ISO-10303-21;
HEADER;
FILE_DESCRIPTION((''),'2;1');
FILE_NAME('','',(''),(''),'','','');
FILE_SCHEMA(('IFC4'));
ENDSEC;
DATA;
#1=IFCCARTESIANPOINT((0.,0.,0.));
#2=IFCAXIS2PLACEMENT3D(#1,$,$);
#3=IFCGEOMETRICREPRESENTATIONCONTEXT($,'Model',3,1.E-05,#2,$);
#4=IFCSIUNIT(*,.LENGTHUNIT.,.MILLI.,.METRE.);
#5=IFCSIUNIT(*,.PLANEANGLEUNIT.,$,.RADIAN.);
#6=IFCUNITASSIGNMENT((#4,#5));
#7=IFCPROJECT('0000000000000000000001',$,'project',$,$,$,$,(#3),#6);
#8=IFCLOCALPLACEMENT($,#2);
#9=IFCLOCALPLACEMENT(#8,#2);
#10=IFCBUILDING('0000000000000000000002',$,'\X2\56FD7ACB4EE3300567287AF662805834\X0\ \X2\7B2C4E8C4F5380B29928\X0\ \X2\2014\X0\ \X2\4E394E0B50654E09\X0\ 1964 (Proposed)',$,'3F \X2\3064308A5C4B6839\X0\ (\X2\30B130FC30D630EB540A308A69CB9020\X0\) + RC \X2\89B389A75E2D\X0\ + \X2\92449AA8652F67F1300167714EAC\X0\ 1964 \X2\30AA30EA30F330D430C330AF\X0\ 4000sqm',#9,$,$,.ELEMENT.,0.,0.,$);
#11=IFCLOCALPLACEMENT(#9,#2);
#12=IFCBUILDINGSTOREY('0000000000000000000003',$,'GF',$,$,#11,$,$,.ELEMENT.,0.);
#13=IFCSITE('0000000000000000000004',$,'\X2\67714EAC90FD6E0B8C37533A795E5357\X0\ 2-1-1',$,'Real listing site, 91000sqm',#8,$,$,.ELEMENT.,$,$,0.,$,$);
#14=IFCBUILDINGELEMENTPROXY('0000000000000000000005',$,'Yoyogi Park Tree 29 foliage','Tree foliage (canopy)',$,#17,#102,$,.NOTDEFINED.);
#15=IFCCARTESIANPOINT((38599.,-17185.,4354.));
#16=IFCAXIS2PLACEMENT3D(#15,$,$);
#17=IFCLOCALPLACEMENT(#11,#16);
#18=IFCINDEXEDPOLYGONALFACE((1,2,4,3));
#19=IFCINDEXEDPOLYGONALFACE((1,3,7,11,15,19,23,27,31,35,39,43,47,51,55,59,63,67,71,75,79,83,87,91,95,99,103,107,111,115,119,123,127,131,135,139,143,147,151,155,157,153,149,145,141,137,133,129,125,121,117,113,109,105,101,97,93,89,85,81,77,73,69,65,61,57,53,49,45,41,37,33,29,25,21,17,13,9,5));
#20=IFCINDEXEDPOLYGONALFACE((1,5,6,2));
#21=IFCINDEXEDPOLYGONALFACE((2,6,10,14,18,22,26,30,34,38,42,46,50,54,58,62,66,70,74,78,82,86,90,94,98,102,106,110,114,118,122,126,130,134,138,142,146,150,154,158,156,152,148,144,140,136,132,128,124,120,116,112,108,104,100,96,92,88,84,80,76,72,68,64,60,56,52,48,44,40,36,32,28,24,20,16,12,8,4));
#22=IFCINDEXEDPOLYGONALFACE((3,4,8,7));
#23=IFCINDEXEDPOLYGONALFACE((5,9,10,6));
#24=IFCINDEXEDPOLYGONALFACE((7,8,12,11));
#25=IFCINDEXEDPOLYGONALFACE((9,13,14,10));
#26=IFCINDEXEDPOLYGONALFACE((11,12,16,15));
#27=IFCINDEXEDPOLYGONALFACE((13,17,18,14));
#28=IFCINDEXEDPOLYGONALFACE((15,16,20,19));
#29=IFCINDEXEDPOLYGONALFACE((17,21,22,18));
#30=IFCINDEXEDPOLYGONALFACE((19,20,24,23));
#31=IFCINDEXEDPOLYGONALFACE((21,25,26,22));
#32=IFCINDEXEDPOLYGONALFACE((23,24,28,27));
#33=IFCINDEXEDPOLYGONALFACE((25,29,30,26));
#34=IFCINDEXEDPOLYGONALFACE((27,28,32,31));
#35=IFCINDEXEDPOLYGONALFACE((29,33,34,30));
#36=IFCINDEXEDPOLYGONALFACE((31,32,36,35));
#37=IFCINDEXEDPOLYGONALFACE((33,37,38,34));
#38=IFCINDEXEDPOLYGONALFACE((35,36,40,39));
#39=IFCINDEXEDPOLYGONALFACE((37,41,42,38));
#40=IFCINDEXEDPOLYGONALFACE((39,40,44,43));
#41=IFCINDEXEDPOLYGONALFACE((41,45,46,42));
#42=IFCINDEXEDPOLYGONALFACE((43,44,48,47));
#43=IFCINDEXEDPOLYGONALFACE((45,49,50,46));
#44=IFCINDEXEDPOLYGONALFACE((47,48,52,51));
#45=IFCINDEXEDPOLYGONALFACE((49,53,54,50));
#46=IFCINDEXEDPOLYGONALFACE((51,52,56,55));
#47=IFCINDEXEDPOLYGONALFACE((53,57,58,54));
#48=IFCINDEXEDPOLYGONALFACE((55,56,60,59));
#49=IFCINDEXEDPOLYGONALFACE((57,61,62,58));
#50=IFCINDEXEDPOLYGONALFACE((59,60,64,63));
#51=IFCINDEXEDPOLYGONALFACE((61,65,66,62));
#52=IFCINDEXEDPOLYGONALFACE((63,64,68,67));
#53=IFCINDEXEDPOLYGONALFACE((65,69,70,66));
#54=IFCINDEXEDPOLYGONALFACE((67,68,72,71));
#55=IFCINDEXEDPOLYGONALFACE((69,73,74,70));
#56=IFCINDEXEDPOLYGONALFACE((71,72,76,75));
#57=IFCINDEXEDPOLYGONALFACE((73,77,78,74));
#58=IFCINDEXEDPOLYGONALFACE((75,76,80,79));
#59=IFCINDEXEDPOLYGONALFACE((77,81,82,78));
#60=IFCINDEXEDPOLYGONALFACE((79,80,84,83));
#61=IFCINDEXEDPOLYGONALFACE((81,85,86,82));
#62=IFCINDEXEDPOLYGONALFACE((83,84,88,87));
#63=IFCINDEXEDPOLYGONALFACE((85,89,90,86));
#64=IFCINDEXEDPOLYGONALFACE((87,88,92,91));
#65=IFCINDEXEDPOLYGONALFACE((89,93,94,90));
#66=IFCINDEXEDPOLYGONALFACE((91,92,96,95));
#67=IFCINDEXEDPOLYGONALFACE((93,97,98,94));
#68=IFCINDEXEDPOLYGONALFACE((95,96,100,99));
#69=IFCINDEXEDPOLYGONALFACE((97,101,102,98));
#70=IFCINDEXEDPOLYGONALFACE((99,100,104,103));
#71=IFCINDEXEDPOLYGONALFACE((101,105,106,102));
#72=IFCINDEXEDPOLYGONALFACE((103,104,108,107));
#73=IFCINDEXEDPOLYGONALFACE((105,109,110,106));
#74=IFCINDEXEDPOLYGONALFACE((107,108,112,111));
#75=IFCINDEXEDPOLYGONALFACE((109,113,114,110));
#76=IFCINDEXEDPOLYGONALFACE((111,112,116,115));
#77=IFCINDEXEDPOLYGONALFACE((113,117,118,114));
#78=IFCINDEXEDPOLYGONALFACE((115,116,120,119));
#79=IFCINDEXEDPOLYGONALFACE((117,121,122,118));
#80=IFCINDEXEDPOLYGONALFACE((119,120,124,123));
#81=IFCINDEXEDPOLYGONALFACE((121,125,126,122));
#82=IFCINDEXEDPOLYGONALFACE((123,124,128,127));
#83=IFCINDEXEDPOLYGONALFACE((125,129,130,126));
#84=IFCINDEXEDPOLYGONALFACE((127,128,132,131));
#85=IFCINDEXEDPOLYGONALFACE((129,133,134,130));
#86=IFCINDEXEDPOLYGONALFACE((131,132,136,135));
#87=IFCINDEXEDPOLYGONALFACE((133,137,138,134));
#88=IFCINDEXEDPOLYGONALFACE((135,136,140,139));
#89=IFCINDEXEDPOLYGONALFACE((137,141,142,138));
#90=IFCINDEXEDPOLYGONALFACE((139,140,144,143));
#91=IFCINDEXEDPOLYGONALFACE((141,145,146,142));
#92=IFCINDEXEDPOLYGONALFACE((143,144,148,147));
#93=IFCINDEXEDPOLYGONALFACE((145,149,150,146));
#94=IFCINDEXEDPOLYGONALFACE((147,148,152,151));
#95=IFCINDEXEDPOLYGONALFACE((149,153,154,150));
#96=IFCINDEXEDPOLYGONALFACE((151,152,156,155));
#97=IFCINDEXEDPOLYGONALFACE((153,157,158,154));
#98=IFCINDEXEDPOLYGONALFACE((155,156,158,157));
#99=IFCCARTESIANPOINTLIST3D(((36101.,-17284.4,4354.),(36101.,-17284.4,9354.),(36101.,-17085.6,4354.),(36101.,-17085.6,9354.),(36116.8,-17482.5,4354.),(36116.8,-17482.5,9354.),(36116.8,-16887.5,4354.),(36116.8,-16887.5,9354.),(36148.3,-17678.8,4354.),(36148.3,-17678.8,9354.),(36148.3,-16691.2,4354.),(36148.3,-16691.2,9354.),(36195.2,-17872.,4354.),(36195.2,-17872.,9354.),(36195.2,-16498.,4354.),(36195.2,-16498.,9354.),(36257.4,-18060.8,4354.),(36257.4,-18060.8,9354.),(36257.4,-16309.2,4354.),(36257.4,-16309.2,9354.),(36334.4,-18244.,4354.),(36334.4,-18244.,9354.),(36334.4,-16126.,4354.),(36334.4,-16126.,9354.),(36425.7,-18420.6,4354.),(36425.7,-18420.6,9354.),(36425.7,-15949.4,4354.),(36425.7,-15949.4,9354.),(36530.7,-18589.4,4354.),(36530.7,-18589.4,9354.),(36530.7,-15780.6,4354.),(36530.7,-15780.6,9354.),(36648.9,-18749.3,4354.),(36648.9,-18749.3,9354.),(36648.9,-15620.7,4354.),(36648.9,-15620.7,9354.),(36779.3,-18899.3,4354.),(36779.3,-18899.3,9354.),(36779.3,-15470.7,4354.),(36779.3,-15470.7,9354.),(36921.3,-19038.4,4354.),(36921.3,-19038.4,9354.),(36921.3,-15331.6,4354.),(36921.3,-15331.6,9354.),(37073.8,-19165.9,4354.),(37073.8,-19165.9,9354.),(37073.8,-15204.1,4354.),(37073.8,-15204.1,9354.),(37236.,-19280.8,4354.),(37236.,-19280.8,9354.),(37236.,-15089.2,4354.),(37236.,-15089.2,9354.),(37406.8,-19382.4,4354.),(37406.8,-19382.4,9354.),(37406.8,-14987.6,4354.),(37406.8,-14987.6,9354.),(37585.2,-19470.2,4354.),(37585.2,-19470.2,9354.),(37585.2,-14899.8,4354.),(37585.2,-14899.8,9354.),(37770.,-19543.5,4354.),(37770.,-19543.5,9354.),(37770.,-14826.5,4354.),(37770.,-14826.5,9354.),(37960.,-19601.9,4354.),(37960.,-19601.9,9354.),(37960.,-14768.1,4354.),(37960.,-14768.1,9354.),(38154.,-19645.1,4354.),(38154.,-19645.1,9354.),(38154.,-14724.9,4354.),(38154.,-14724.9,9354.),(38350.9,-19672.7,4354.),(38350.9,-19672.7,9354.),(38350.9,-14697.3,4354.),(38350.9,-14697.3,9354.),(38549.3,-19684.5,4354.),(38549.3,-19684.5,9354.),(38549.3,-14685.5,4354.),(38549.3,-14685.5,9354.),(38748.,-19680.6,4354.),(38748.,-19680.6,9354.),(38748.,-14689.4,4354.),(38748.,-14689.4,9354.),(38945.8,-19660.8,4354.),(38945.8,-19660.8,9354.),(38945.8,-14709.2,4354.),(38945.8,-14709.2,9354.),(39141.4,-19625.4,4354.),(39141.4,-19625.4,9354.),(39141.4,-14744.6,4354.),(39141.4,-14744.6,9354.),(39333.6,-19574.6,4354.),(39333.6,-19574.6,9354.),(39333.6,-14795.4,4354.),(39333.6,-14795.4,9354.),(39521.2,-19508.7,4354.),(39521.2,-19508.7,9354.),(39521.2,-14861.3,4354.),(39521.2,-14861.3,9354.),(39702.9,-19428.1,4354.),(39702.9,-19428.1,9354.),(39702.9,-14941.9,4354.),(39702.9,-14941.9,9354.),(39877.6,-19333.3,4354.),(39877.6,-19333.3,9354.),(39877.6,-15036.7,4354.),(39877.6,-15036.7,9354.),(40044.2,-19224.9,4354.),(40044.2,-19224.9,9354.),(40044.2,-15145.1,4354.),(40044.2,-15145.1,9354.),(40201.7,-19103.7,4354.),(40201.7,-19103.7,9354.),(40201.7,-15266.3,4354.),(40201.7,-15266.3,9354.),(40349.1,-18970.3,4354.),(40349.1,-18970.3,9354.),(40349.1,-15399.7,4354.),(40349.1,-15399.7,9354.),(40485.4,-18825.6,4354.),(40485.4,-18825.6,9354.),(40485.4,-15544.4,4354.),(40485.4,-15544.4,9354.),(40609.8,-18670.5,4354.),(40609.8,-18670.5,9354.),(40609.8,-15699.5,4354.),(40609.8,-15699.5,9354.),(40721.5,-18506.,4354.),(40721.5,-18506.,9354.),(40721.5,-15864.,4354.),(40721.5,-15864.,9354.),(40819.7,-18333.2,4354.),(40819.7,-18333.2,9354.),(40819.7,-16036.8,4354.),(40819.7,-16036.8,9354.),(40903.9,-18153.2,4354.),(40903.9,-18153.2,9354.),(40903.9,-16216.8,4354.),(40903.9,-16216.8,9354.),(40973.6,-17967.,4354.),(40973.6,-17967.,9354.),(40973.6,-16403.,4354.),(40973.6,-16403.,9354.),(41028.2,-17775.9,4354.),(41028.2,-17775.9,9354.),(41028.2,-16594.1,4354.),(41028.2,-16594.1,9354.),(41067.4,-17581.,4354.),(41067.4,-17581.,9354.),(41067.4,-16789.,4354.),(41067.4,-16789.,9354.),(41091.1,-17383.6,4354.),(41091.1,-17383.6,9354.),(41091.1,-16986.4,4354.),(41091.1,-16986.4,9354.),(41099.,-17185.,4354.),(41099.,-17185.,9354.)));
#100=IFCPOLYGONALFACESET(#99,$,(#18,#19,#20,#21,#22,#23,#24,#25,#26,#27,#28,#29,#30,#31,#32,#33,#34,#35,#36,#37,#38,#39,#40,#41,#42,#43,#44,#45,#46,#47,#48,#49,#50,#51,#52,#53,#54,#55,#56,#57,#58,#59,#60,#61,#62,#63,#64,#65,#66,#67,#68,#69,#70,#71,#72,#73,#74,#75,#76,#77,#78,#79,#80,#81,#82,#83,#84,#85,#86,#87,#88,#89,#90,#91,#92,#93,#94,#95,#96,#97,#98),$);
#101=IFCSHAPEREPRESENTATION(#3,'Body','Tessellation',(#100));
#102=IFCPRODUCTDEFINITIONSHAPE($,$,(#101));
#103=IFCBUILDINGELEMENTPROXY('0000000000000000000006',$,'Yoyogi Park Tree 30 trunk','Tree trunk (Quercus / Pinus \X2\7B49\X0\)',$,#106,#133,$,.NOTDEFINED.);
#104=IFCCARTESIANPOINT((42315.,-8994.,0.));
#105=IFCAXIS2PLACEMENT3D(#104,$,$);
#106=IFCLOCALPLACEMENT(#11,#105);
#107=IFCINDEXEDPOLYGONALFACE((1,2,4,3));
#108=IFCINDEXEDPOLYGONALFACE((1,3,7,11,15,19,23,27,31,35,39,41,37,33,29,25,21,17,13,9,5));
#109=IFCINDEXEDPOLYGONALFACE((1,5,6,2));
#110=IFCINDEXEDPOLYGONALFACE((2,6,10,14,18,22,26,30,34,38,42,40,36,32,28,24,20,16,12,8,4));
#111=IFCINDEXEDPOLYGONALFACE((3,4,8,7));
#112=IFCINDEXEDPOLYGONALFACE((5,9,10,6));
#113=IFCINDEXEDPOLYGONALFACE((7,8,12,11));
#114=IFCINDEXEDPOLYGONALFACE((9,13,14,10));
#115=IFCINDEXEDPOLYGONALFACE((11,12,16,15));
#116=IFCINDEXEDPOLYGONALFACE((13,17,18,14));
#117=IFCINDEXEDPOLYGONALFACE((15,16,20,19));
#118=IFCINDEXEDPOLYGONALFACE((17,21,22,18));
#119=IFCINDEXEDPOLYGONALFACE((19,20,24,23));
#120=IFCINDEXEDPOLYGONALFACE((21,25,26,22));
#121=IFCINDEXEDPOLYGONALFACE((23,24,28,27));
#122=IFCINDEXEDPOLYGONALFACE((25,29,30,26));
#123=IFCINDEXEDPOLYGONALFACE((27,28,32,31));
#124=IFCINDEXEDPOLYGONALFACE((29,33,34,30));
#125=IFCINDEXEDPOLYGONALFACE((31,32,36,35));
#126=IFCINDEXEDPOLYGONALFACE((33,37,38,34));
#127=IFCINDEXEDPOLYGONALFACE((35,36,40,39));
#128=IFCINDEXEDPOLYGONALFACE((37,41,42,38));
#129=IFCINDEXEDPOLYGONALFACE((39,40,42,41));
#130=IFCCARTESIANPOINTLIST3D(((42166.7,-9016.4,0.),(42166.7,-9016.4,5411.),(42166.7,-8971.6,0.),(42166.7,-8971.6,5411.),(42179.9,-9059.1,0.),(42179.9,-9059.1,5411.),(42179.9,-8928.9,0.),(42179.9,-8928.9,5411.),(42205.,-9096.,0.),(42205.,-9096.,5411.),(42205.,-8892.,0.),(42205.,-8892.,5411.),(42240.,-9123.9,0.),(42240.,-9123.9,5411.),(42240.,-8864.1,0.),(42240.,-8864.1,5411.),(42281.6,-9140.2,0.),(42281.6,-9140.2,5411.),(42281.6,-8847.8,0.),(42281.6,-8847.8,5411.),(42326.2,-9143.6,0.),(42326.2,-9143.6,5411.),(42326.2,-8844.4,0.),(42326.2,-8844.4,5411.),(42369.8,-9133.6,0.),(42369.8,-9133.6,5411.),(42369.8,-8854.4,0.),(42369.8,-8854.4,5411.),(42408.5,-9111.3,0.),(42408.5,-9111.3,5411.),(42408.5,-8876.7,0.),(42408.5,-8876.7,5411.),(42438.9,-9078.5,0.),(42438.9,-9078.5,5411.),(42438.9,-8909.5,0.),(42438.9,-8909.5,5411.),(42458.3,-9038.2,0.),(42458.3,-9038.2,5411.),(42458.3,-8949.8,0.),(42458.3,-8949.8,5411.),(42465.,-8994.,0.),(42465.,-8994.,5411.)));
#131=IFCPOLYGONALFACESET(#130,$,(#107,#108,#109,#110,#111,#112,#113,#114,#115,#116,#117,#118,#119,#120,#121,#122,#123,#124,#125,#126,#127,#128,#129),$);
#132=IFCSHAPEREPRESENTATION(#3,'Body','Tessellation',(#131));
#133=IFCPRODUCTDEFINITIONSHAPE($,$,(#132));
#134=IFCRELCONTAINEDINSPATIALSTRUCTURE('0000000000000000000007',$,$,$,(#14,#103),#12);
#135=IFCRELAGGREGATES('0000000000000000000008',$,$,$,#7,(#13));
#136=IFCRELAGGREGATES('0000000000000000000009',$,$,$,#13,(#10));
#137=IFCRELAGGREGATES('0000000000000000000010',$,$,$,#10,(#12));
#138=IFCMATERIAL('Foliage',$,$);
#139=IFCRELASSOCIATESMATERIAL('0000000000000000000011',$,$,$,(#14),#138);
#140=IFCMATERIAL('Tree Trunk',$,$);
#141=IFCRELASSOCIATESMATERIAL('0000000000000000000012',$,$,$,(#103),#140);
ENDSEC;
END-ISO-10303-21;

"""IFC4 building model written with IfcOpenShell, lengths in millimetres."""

from ifc_helpers import new_model, si_unit, frame, origin, origin_2d, place, context, project, spatial, circle, extrude, material, element, save


model = new_model("IFC4")

# Units and contexts
model_context = context("Model", 3, precision=1e-05, world=origin())
ifc_project = project(units=[si_unit("LENGTHUNIT", "METRE", prefix="MILLI"), si_unit("PLANEANGLEUNIT", "RADIAN")], contexts=[model_context])

# Site, building, storey
site_placement = place(None, origin())
site = spatial("IfcSite", under=ifc_project, at=site_placement, Name="東京都渋谷区神南 2-1-1", ObjectType="Real listing site, 91000sqm", CompositionType="ELEMENT", RefElevation=0.0)
building_placement = place(site_placement, origin())
building = spatial("IfcBuilding", under=site, at=building_placement, Name="国立代々木競技場 第二体育館 — 丹下健三 1964 (Proposed)", ObjectType="3F つり屋根 (ケーブル吊り構造) + RC 観覧席 + 鉄骨支柱、東京 1964 オリンピック 4000sqm", CompositionType="ELEMENT", ElevationOfRefHeight=0.0, ElevationOfTerrain=0.0)
storey_placement = place(building_placement, origin())
storey = spatial("IfcBuildingStorey", under=building, at=storey_placement, Name="GF", CompositionType="ELEMENT", Elevation=0.0)

# Building element proxies
ifc_material_1 = material(Name="Tree Trunk")
ifc_material_2 = material(Name="Foliage")
proxy_1_placement = place(storey_placement, frame((38599.0, -17185.0, 4354.0)))
element("IfcBuildingElementProxy", 1, at=proxy_1_placement, inside=storey, material=ifc_material_2, Name="Yoyogi Park Tree 29 foliage", Description="Tree foliage (canopy)", PredefinedType="NOTDEFINED", context=model_context, shape_type="SweptSolid", body=[
    extrude(circle(Radius=2500.0, at=origin_2d()), frame((38599.0, -17185.0, 4354.0)), (0.0, 0.0, 1.0), 5000.0),
])
proxy_2_placement = place(storey_placement, frame((42315.0, -8994.0, 0.0)))
element("IfcBuildingElementProxy", 2, at=proxy_2_placement, inside=storey, material=ifc_material_1, Name="Yoyogi Park Tree 30 trunk", Description="Tree trunk (Quercus / Pinus 等)", PredefinedType="NOTDEFINED", context=model_context, shape_type="SweptSolid", body=[
    extrude(circle(Radius=150.0, at=origin_2d()), frame((42315.0, -8994.0, 0.0)), (0.0, 0.0, 1.0), 5411.0),
])

save(model, "model.ifc")
